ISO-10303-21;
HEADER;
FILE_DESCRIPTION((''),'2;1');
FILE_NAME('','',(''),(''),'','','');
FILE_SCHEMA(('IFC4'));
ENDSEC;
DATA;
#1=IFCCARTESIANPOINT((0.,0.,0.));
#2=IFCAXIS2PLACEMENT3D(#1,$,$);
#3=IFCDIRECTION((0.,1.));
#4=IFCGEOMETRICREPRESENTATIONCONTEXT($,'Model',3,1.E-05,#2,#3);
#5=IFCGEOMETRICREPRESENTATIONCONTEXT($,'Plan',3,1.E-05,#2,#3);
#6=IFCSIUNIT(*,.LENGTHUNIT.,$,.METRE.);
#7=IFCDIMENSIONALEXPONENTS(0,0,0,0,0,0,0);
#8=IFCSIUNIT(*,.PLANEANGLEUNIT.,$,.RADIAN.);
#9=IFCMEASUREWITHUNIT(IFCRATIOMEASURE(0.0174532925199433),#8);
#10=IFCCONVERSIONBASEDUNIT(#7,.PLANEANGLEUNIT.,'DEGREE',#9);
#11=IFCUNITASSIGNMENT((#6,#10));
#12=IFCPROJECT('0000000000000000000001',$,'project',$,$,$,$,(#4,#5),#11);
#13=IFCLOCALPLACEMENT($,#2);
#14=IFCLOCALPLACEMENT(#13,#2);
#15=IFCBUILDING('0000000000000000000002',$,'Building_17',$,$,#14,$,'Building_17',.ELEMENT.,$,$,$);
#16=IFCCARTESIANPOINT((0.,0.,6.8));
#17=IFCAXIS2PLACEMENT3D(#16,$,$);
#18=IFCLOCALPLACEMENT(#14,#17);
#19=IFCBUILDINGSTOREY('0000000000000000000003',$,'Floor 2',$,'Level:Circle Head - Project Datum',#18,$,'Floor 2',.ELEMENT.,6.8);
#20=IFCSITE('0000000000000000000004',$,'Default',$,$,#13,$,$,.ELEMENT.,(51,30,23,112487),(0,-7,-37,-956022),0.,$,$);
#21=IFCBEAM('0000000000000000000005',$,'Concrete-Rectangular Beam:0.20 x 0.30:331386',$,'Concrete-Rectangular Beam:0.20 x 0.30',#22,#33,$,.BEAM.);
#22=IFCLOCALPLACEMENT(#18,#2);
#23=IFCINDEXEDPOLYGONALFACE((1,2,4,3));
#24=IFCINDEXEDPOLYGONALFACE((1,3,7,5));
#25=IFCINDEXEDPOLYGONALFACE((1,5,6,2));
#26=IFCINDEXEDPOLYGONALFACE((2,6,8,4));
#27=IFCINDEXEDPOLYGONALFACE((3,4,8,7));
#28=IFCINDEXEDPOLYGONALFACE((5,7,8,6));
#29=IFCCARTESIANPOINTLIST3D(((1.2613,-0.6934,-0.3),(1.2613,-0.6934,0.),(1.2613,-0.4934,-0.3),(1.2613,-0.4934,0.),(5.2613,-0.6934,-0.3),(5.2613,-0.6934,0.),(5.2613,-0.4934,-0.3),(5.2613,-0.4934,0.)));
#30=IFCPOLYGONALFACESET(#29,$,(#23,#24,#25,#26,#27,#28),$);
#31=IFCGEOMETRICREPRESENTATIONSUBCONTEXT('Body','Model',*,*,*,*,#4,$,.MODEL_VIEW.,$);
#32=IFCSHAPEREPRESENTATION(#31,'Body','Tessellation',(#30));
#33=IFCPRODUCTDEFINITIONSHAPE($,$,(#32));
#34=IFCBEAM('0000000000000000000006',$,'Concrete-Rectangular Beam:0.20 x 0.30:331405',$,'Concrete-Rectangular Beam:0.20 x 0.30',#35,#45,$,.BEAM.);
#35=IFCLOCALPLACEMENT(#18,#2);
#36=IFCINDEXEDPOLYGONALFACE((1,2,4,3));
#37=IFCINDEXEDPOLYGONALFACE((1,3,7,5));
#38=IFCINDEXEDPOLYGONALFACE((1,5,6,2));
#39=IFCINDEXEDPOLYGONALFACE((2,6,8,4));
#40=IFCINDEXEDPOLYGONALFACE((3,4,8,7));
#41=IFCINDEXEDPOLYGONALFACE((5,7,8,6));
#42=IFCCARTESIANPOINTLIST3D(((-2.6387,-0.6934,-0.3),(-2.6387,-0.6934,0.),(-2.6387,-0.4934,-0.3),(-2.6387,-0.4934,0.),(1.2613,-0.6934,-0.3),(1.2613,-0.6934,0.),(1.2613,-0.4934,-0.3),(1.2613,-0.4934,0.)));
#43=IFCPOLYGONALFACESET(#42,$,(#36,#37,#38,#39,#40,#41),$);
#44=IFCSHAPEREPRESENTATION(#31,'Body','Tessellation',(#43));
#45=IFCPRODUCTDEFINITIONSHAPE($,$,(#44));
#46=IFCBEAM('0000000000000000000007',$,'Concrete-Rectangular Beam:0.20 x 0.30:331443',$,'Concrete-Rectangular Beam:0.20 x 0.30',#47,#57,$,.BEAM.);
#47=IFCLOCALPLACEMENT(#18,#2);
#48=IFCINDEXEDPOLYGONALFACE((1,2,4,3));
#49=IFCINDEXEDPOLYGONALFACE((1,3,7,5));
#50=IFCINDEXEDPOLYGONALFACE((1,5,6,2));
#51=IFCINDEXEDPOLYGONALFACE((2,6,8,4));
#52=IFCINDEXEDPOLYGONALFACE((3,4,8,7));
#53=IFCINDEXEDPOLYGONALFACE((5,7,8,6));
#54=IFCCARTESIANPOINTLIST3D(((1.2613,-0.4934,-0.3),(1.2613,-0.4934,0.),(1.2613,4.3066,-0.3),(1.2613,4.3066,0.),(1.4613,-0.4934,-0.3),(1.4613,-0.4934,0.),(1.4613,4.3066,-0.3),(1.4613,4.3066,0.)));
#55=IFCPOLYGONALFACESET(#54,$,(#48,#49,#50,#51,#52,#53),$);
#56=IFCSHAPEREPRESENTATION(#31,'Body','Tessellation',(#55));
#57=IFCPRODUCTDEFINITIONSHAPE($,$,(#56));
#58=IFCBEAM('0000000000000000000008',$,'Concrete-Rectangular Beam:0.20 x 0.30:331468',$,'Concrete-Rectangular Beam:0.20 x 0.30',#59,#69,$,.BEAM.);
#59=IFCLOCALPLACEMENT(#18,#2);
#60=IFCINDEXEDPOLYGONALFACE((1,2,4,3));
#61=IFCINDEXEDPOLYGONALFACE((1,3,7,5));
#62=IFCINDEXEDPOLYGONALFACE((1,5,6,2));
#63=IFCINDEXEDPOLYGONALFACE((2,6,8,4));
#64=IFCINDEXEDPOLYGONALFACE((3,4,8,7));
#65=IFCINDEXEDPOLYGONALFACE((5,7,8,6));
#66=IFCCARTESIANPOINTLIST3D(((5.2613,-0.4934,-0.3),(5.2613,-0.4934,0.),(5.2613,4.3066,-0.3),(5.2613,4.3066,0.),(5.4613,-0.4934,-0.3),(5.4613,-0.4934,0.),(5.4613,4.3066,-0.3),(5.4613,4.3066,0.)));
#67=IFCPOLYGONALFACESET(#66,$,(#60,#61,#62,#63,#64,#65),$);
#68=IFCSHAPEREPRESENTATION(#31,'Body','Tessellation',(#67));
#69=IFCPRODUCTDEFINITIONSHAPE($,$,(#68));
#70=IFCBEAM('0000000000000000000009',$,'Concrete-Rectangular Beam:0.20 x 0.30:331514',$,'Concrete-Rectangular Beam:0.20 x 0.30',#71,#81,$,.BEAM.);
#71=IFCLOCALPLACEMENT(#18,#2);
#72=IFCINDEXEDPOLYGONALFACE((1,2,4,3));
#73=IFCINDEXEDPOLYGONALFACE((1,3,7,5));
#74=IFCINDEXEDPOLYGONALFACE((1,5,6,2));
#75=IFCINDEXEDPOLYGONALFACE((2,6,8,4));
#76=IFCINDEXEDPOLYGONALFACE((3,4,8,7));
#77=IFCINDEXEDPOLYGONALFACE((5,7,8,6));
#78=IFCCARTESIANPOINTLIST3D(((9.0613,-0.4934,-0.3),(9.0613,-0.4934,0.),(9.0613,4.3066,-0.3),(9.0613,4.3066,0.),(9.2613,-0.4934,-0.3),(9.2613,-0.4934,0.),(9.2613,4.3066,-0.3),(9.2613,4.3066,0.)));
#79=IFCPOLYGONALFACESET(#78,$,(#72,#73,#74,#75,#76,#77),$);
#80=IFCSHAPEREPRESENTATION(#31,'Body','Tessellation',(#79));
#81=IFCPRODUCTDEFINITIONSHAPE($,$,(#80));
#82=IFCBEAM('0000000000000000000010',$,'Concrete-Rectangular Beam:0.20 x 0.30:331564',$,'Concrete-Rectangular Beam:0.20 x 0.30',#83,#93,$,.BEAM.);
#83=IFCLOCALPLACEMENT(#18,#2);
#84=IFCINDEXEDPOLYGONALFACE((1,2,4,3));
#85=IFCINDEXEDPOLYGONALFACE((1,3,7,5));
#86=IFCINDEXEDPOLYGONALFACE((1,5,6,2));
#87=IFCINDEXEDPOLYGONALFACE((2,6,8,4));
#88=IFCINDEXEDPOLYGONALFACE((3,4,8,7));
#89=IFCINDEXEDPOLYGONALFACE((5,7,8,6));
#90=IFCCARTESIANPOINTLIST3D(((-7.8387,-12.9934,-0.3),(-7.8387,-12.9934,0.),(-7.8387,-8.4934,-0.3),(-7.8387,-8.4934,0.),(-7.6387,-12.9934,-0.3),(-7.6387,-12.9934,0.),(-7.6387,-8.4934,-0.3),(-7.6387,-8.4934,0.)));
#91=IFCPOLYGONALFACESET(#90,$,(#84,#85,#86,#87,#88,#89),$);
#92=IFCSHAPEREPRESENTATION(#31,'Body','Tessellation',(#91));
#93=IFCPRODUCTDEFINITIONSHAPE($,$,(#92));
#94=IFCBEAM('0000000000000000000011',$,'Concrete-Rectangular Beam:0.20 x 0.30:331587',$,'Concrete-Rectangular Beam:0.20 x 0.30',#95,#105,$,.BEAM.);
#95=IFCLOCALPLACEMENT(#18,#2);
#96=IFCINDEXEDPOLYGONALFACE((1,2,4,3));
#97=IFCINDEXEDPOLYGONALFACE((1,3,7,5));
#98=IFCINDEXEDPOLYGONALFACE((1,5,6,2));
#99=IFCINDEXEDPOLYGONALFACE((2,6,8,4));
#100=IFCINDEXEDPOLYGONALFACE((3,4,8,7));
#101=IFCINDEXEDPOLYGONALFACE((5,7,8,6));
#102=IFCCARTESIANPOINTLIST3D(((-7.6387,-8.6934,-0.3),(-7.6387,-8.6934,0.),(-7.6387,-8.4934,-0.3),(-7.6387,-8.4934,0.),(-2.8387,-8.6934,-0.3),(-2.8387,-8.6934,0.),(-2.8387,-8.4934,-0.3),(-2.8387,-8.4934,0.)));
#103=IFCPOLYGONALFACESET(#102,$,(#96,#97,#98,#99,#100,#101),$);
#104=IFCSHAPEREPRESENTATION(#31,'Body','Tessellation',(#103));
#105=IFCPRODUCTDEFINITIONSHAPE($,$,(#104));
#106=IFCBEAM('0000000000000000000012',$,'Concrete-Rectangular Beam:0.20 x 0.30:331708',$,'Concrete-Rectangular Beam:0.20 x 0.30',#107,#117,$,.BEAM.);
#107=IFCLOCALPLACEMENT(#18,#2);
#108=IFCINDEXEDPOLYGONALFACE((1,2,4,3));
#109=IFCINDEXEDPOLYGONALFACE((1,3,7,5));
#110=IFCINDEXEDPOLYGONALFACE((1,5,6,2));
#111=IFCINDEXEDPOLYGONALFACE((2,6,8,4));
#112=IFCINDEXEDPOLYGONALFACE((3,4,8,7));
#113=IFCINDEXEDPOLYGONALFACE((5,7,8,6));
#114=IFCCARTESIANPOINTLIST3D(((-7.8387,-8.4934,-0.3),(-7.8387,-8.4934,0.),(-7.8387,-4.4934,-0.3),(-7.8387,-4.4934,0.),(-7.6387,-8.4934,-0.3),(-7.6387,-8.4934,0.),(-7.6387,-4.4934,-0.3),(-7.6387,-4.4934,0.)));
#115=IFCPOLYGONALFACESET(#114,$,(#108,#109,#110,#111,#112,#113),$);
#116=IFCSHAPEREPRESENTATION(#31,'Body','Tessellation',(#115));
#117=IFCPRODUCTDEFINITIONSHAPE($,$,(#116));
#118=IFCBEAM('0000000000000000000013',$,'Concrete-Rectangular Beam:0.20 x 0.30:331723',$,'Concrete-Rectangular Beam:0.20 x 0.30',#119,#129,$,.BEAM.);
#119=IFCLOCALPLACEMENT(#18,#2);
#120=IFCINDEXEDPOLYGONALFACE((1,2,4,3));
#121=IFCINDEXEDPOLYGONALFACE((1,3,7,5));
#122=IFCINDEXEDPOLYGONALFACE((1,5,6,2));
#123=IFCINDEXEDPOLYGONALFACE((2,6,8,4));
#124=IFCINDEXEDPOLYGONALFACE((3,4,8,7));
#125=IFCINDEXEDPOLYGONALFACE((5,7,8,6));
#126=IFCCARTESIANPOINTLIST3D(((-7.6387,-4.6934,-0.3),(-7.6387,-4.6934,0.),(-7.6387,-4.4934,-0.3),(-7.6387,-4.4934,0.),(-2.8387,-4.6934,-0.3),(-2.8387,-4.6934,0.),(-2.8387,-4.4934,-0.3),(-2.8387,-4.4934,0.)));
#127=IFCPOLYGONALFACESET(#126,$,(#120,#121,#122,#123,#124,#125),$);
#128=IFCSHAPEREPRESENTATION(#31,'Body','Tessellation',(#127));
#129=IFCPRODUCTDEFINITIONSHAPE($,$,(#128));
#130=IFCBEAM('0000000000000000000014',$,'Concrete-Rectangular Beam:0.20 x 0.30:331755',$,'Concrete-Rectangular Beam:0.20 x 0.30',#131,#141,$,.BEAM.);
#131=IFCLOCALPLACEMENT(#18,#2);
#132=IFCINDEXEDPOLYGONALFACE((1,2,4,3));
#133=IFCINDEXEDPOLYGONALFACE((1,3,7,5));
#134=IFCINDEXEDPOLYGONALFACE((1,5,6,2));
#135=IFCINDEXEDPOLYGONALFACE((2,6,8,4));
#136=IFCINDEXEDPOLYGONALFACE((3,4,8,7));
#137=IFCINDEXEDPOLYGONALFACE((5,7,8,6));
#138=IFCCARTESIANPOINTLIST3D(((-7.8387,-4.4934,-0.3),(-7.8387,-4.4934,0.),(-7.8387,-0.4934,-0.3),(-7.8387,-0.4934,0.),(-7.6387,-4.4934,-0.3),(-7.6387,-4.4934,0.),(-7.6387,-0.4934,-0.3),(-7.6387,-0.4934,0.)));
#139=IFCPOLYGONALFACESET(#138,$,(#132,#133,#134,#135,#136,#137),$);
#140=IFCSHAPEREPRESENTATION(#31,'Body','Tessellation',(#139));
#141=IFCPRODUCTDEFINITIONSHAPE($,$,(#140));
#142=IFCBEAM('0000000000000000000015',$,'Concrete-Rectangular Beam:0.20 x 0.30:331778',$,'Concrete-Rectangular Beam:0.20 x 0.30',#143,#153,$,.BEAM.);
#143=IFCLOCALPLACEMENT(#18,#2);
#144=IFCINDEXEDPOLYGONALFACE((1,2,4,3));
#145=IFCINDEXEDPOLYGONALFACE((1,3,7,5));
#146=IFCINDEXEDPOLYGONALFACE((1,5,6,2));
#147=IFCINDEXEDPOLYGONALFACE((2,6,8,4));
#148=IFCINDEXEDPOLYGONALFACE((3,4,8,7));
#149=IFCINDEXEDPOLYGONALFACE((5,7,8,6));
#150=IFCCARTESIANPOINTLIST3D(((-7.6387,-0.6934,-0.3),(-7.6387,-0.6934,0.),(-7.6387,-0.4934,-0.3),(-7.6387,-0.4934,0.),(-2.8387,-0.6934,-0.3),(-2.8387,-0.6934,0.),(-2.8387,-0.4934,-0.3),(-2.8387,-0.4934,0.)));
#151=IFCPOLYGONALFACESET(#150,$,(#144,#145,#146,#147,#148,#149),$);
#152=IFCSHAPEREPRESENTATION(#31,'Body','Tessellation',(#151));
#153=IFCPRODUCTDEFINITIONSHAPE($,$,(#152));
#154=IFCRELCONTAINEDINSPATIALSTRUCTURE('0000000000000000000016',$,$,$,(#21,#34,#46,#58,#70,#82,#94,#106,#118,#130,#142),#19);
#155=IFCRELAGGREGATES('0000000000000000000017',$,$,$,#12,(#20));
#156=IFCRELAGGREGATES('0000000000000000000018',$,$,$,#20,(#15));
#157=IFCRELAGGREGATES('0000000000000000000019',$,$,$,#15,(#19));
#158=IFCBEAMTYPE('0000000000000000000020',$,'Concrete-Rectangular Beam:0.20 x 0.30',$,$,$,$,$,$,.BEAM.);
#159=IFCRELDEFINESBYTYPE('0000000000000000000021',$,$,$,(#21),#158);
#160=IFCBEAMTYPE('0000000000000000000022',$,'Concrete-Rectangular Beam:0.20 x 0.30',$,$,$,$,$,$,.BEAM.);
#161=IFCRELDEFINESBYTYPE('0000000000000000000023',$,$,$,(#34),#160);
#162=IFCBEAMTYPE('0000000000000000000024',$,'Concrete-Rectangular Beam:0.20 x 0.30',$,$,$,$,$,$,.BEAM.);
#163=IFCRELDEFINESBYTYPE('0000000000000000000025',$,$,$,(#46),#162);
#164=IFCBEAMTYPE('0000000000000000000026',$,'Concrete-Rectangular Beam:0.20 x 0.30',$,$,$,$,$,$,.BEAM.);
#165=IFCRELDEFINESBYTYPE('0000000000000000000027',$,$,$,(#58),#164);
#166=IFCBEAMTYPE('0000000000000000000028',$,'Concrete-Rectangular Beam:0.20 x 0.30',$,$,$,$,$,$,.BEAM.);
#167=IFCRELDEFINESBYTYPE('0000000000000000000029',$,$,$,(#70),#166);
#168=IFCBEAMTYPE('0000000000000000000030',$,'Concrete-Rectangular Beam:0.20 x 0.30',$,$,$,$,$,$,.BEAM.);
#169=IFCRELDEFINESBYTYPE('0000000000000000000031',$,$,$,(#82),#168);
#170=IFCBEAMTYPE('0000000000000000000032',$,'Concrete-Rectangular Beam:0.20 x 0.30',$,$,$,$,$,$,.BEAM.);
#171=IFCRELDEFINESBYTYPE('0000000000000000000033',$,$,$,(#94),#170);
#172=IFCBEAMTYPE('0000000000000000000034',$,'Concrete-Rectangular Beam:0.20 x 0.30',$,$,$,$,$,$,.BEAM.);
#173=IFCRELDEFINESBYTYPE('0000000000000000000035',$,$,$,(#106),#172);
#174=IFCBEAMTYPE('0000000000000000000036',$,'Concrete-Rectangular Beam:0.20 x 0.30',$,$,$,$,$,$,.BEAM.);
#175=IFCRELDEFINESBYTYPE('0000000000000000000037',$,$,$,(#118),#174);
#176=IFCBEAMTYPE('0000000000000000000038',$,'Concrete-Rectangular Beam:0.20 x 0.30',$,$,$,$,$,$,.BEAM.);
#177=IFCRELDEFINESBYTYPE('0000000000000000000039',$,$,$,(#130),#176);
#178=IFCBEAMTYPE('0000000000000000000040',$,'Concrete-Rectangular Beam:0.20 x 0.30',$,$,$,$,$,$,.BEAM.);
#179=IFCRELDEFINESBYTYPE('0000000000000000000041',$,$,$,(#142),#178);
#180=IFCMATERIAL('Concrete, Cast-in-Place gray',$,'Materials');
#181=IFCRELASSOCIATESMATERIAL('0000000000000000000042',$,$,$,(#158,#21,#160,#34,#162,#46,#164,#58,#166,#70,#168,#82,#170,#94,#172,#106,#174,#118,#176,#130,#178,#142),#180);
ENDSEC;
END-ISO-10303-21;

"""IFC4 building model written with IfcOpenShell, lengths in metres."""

from ifc_helpers import new_model, entity, si_unit, converted_unit, direction, frame, origin, place, context, subcontext, project, spatial, indexed_curve, outline, extrude, source, transform, mapped, material, type_object, type_shapes, element, save


model = new_model("IFC4")

# Units and contexts
model_context = context("Model", 3, precision=1e-05, world=origin(), true_north=direction((0.0, 1.0)))
plan_context = context("Plan", 3, precision=1e-05, world=origin(), true_north=direction((0.0, 1.0)))
body_context = subcontext(model_context, "Body", "Model", "MODEL_VIEW")
ifc_project = project(units=[si_unit("LENGTHUNIT", "METRE"), converted_unit("PLANEANGLEUNIT", "DEGREE", entity("IfcRatioMeasure", 0.0174532925199433), si_unit("PLANEANGLEUNIT", "RADIAN"), dimensions=[0, 0, 0, 0, 0, 0, 0])], contexts=[model_context, plan_context])

# Site, building, storey
site_placement = place(None, origin())
site = spatial("IfcSite", under=ifc_project, at=site_placement, Name="Default", CompositionType="ELEMENT", RefLatitude=(51, 30, 23, 112487), RefLongitude=(0, -7, -37, -956022), RefElevation=0.0)
building_placement = place(site_placement, origin())
building = spatial("IfcBuilding", under=site, at=building_placement, Name="Building_17", LongName="Building_17", CompositionType="ELEMENT")
storey_placement = place(building_placement, frame((0.0, 0.0, 6.8)))
storey = spatial("IfcBuildingStorey", under=building, at=storey_placement, Name="Floor 2", ObjectType="Level:Circle Head - Project Datum", LongName="Floor 2", CompositionType="ELEMENT", Elevation=6.8)

# Beams
ifc_material = material(Name="Concrete, Cast-in-Place gray", Category="Materials")
beam_type_1 = type_object("IfcBeamType", Name="Concrete-Rectangular Beam:0.20 x 0.30", PredefinedType="BEAM", material=ifc_material)
shared_shape_1 = source(origin(), body_context, "Body", "SweptSolid", [
    extrude(outline(indexed_curve([(-0.15, -0.1), (0.15, -0.1), (0.15, 0.1), (-0.15, 0.1), (-0.15, -0.1)], self_intersect=False)), frame((5.2613, -0.5934, 6.65), z_axis=(-1.0, 0.0, 0.0), x_axis=(0.0, 0.0, -1.0)), (0.0, 0.0, 1.0), 4.0),
])
type_shapes(beam_type_1, [shared_shape_1])
beam_1_placement = place(storey_placement, frame((0.0, 0.0, -6.8)))
element("IfcBeam", 1, at=beam_1_placement, inside=storey, type_object=beam_type_1, material=ifc_material, Name="Concrete-Rectangular Beam:0.20 x 0.30:331386", ObjectType="Concrete-Rectangular Beam:0.20 x 0.30", PredefinedType="BEAM", context=body_context, shape_type="MappedRepresentation", body=[
    mapped(shared_shape_1, transform((0.0, 0.0, 0.0), scale=1.0)),
])
beam_type_2 = type_object("IfcBeamType", Name="Concrete-Rectangular Beam:0.20 x 0.30", PredefinedType="BEAM", material=ifc_material)
shared_shape_2 = source(origin(), body_context, "Body", "SweptSolid", [
    extrude(outline(indexed_curve([(-0.15, -0.1), (0.15, -0.1), (0.15, 0.1), (-0.15, 0.1), (-0.15, -0.1)], self_intersect=False)), frame((1.2613, -0.5934, 6.65), z_axis=(-1.0, 0.0, 0.0), x_axis=(0.0, 0.0, -1.0)), (0.0, 0.0, 1.0), 3.9),
])
type_shapes(beam_type_2, [shared_shape_2])
beam_2_placement = place(storey_placement, frame((0.0, 0.0, -6.8)))
element("IfcBeam", 2, at=beam_2_placement, inside=storey, type_object=beam_type_2, material=ifc_material, Name="Concrete-Rectangular Beam:0.20 x 0.30:331405", ObjectType="Concrete-Rectangular Beam:0.20 x 0.30", PredefinedType="BEAM", context=body_context, shape_type="MappedRepresentation", body=[
    mapped(shared_shape_2, transform((0.0, 0.0, 0.0), scale=1.0)),
])
beam_type_3 = type_object("IfcBeamType", Name="Concrete-Rectangular Beam:0.20 x 0.30", PredefinedType="BEAM", material=ifc_material)
shared_shape_3 = source(origin(), body_context, "Body", "SweptSolid", [
    extrude(outline(indexed_curve([(-0.1, -0.15), (0.1, -0.15), (0.1, 0.15), (-0.1, 0.15), (-0.1, -0.15)], self_intersect=False)), frame((1.3613, -0.4934, 6.65), z_axis=(0.0, 1.0, 0.0), x_axis=(-1.0, 0.0, 0.0)), (0.0, 0.0, 1.0), 4.8),
])
type_shapes(beam_type_3, [shared_shape_3])
beam_3_placement = place(storey_placement, frame((0.0, 0.0, -6.8)))
element("IfcBeam", 3, at=beam_3_placement, inside=storey, type_object=beam_type_3, material=ifc_material, Name="Concrete-Rectangular Beam:0.20 x 0.30:331443", ObjectType="Concrete-Rectangular Beam:0.20 x 0.30", PredefinedType="BEAM", context=body_context, shape_type="MappedRepresentation", body=[
    mapped(shared_shape_3, transform((0.0, 0.0, 0.0), scale=1.0)),
])
beam_type_4 = type_object("IfcBeamType", Name="Concrete-Rectangular Beam:0.20 x 0.30", PredefinedType="BEAM", material=ifc_material)
shared_shape_4 = source(origin(), body_context, "Body", "SweptSolid", [
    extrude(outline(indexed_curve([(-0.1, -0.15), (0.1, -0.15), (0.1, 0.15), (-0.1, 0.15), (-0.1, -0.15)], self_intersect=False)), frame((5.3613, 4.3066, 6.65), z_axis=(0.0, -1.0, 0.0), x_axis=(-1.0, 0.0, 0.0)), (0.0, 0.0, 1.0), 4.8),
])
type_shapes(beam_type_4, [shared_shape_4])
beam_4_placement = place(storey_placement, frame((0.0, 0.0, -6.8)))
element("IfcBeam", 4, at=beam_4_placement, inside=storey, type_object=beam_type_4, material=ifc_material, Name="Concrete-Rectangular Beam:0.20 x 0.30:331468", ObjectType="Concrete-Rectangular Beam:0.20 x 0.30", PredefinedType="BEAM", context=body_context, shape_type="MappedRepresentation", body=[
    mapped(shared_shape_4, transform((0.0, 0.0, 0.0), scale=1.0)),
])
beam_type_5 = type_object("IfcBeamType", Name="Concrete-Rectangular Beam:0.20 x 0.30", PredefinedType="BEAM", material=ifc_material)
shared_shape_5 = source(origin(), body_context, "Body", "SweptSolid", [
    extrude(outline(indexed_curve([(-0.1, -0.15), (0.1, -0.15), (0.1, 0.15), (-0.1, 0.15), (-0.1, -0.15)], self_intersect=False)), frame((9.1613, 4.3066, 6.65), z_axis=(0.0, -1.0, 0.0), x_axis=(-1.0, 0.0, 0.0)), (0.0, 0.0, 1.0), 4.8),
])
type_shapes(beam_type_5, [shared_shape_5])
beam_5_placement = place(storey_placement, frame((0.0, 0.0, -6.8)))
element("IfcBeam", 5, at=beam_5_placement, inside=storey, type_object=beam_type_5, material=ifc_material, Name="Concrete-Rectangular Beam:0.20 x 0.30:331514", ObjectType="Concrete-Rectangular Beam:0.20 x 0.30", PredefinedType="BEAM", context=body_context, shape_type="MappedRepresentation", body=[
    mapped(shared_shape_5, transform((0.0, 0.0, 0.0), scale=1.0)),
])
beam_type_6 = type_object("IfcBeamType", Name="Concrete-Rectangular Beam:0.20 x 0.30", PredefinedType="BEAM", material=ifc_material)
shared_shape_6 = source(origin(), body_context, "Body", "SweptSolid", [
    extrude(outline(indexed_curve([(-0.1, -0.15), (0.1, -0.15), (0.1, 0.15), (-0.1, 0.15), (-0.1, -0.15)], self_intersect=False)), frame((-7.7387, -12.9934, 6.65), z_axis=(0.0, 1.0, 0.0), x_axis=(-1.0, 0.0, 0.0)), (0.0, 0.0, 1.0), 4.5),
])
type_shapes(beam_type_6, [shared_shape_6])
beam_6_placement = place(storey_placement, frame((0.0, 0.0, -6.8)))
element("IfcBeam", 6, at=beam_6_placement, inside=storey, type_object=beam_type_6, material=ifc_material, Name="Concrete-Rectangular Beam:0.20 x 0.30:331564", ObjectType="Concrete-Rectangular Beam:0.20 x 0.30", PredefinedType="BEAM", context=body_context, shape_type="MappedRepresentation", body=[
    mapped(shared_shape_6, transform((0.0, 0.0, 0.0), scale=1.0)),
])
beam_type_7 = type_object("IfcBeamType", Name="Concrete-Rectangular Beam:0.20 x 0.30", PredefinedType="BEAM", material=ifc_material)
shared_shape_7 = source(origin(), body_context, "Body", "SweptSolid", [
    extrude(outline(indexed_curve([(-0.15, -0.1), (0.15, -0.1), (0.15, 0.1), (-0.15, 0.1), (-0.15, -0.1)], self_intersect=False)), frame((-7.6387, -8.5934, 6.65), z_axis=(1.0, 0.0, 0.0), x_axis=(0.0, 0.0, -1.0)), (0.0, 0.0, 1.0), 4.8),
])
type_shapes(beam_type_7, [shared_shape_7])
beam_7_placement = place(storey_placement, frame((0.0, 0.0, -6.8)))
element("IfcBeam", 7, at=beam_7_placement, inside=storey, type_object=beam_type_7, material=ifc_material, Name="Concrete-Rectangular Beam:0.20 x 0.30:331587", ObjectType="Concrete-Rectangular Beam:0.20 x 0.30", PredefinedType="BEAM", context=body_context, shape_type="MappedRepresentation", body=[
    mapped(shared_shape_7, transform((0.0, 0.0, 0.0), scale=1.0)),
])
beam_type_8 = type_object("IfcBeamType", Name="Concrete-Rectangular Beam:0.20 x 0.30", PredefinedType="BEAM", material=ifc_material)
shared_shape_8 = source(origin(), body_context, "Body", "SweptSolid", [
    extrude(outline(indexed_curve([(-0.1, -0.15), (0.1, -0.15), (0.1, 0.15), (-0.1, 0.15), (-0.1, -0.15)], self_intersect=False)), frame((-7.7387, -8.4934, 6.65), z_axis=(0.0, 1.0, 0.0), x_axis=(-1.0, 0.0, 0.0)), (0.0, 0.0, 1.0), 4.0),
])
type_shapes(beam_type_8, [shared_shape_8])
beam_8_placement = place(storey_placement, frame((0.0, 0.0, -6.8)))
element("IfcBeam", 8, at=beam_8_placement, inside=storey, type_object=beam_type_8, material=ifc_material, Name="Concrete-Rectangular Beam:0.20 x 0.30:331708", ObjectType="Concrete-Rectangular Beam:0.20 x 0.30", PredefinedType="BEAM", context=body_context, shape_type="MappedRepresentation", body=[
    mapped(shared_shape_8, transform((0.0, 0.0, 0.0), scale=1.0)),
])
beam_type_9 = type_object("IfcBeamType", Name="Concrete-Rectangular Beam:0.20 x 0.30", PredefinedType="BEAM", material=ifc_material)
shared_shape_9 = source(origin(), body_context, "Body", "SweptSolid", [
    extrude(outline(indexed_curve([(-0.15, -0.1), (0.15, -0.1), (0.15, 0.1), (-0.15, 0.1), (-0.15, -0.1)], self_intersect=False)), frame((-7.6387, -4.5934, 6.65), z_axis=(1.0, 0.0, 0.0), x_axis=(0.0, 0.0, -1.0)), (0.0, 0.0, 1.0), 4.8),
])
type_shapes(beam_type_9, [shared_shape_9])
beam_9_placement = place(storey_placement, frame((0.0, 0.0, -6.8)))
element("IfcBeam", 9, at=beam_9_placement, inside=storey, type_object=beam_type_9, material=ifc_material, Name="Concrete-Rectangular Beam:0.20 x 0.30:331723", ObjectType="Concrete-Rectangular Beam:0.20 x 0.30", PredefinedType="BEAM", context=body_context, shape_type="MappedRepresentation", body=[
    mapped(shared_shape_9, transform((0.0, 0.0, 0.0), scale=1.0)),
])
beam_type_10 = type_object("IfcBeamType", Name="Concrete-Rectangular Beam:0.20 x 0.30", PredefinedType="BEAM", material=ifc_material)
shared_shape_10 = source(origin(), body_context, "Body", "SweptSolid", [
    extrude(outline(indexed_curve([(-0.1, -0.15), (0.1, -0.15), (0.1, 0.15), (-0.1, 0.15), (-0.1, -0.15)], self_intersect=False)), frame((-7.7387, -4.4934, 6.65), z_axis=(0.0, 1.0, 0.0), x_axis=(-1.0, 0.0, 0.0)), (0.0, 0.0, 1.0), 4.0),
])
type_shapes(beam_type_10, [shared_shape_10])
beam_10_placement = place(storey_placement, frame((0.0, 0.0, -6.8)))
element("IfcBeam", 10, at=beam_10_placement, inside=storey, type_object=beam_type_10, material=ifc_material, Name="Concrete-Rectangular Beam:0.20 x 0.30:331755", ObjectType="Concrete-Rectangular Beam:0.20 x 0.30", PredefinedType="BEAM", context=body_context, shape_type="MappedRepresentation", body=[
    mapped(shared_shape_10, transform((0.0, 0.0, 0.0), scale=1.0)),
])
beam_type_11 = type_object("IfcBeamType", Name="Concrete-Rectangular Beam:0.20 x 0.30", PredefinedType="BEAM", material=ifc_material)
shared_shape_11 = source(origin(), body_context, "Body", "SweptSolid", [
    extrude(outline(indexed_curve([(-0.15, -0.1), (0.15, -0.1), (0.15, 0.1), (-0.15, 0.1), (-0.15, -0.1)], self_intersect=False)), frame((-7.6387, -0.5934, 6.65), z_axis=(1.0, 0.0, 0.0), x_axis=(0.0, 0.0, -1.0)), (0.0, 0.0, 1.0), 4.8),
])
type_shapes(beam_type_11, [shared_shape_11])
beam_11_placement = place(storey_placement, frame((0.0, 0.0, -6.8)))
element("IfcBeam", 11, at=beam_11_placement, inside=storey, type_object=beam_type_11, material=ifc_material, Name="Concrete-Rectangular Beam:0.20 x 0.30:331778", ObjectType="Concrete-Rectangular Beam:0.20 x 0.30", PredefinedType="BEAM", context=body_context, shape_type="MappedRepresentation", body=[
    mapped(shared_shape_11, transform((0.0, 0.0, 0.0), scale=1.0)),
])

save(model, "model.ifc")
